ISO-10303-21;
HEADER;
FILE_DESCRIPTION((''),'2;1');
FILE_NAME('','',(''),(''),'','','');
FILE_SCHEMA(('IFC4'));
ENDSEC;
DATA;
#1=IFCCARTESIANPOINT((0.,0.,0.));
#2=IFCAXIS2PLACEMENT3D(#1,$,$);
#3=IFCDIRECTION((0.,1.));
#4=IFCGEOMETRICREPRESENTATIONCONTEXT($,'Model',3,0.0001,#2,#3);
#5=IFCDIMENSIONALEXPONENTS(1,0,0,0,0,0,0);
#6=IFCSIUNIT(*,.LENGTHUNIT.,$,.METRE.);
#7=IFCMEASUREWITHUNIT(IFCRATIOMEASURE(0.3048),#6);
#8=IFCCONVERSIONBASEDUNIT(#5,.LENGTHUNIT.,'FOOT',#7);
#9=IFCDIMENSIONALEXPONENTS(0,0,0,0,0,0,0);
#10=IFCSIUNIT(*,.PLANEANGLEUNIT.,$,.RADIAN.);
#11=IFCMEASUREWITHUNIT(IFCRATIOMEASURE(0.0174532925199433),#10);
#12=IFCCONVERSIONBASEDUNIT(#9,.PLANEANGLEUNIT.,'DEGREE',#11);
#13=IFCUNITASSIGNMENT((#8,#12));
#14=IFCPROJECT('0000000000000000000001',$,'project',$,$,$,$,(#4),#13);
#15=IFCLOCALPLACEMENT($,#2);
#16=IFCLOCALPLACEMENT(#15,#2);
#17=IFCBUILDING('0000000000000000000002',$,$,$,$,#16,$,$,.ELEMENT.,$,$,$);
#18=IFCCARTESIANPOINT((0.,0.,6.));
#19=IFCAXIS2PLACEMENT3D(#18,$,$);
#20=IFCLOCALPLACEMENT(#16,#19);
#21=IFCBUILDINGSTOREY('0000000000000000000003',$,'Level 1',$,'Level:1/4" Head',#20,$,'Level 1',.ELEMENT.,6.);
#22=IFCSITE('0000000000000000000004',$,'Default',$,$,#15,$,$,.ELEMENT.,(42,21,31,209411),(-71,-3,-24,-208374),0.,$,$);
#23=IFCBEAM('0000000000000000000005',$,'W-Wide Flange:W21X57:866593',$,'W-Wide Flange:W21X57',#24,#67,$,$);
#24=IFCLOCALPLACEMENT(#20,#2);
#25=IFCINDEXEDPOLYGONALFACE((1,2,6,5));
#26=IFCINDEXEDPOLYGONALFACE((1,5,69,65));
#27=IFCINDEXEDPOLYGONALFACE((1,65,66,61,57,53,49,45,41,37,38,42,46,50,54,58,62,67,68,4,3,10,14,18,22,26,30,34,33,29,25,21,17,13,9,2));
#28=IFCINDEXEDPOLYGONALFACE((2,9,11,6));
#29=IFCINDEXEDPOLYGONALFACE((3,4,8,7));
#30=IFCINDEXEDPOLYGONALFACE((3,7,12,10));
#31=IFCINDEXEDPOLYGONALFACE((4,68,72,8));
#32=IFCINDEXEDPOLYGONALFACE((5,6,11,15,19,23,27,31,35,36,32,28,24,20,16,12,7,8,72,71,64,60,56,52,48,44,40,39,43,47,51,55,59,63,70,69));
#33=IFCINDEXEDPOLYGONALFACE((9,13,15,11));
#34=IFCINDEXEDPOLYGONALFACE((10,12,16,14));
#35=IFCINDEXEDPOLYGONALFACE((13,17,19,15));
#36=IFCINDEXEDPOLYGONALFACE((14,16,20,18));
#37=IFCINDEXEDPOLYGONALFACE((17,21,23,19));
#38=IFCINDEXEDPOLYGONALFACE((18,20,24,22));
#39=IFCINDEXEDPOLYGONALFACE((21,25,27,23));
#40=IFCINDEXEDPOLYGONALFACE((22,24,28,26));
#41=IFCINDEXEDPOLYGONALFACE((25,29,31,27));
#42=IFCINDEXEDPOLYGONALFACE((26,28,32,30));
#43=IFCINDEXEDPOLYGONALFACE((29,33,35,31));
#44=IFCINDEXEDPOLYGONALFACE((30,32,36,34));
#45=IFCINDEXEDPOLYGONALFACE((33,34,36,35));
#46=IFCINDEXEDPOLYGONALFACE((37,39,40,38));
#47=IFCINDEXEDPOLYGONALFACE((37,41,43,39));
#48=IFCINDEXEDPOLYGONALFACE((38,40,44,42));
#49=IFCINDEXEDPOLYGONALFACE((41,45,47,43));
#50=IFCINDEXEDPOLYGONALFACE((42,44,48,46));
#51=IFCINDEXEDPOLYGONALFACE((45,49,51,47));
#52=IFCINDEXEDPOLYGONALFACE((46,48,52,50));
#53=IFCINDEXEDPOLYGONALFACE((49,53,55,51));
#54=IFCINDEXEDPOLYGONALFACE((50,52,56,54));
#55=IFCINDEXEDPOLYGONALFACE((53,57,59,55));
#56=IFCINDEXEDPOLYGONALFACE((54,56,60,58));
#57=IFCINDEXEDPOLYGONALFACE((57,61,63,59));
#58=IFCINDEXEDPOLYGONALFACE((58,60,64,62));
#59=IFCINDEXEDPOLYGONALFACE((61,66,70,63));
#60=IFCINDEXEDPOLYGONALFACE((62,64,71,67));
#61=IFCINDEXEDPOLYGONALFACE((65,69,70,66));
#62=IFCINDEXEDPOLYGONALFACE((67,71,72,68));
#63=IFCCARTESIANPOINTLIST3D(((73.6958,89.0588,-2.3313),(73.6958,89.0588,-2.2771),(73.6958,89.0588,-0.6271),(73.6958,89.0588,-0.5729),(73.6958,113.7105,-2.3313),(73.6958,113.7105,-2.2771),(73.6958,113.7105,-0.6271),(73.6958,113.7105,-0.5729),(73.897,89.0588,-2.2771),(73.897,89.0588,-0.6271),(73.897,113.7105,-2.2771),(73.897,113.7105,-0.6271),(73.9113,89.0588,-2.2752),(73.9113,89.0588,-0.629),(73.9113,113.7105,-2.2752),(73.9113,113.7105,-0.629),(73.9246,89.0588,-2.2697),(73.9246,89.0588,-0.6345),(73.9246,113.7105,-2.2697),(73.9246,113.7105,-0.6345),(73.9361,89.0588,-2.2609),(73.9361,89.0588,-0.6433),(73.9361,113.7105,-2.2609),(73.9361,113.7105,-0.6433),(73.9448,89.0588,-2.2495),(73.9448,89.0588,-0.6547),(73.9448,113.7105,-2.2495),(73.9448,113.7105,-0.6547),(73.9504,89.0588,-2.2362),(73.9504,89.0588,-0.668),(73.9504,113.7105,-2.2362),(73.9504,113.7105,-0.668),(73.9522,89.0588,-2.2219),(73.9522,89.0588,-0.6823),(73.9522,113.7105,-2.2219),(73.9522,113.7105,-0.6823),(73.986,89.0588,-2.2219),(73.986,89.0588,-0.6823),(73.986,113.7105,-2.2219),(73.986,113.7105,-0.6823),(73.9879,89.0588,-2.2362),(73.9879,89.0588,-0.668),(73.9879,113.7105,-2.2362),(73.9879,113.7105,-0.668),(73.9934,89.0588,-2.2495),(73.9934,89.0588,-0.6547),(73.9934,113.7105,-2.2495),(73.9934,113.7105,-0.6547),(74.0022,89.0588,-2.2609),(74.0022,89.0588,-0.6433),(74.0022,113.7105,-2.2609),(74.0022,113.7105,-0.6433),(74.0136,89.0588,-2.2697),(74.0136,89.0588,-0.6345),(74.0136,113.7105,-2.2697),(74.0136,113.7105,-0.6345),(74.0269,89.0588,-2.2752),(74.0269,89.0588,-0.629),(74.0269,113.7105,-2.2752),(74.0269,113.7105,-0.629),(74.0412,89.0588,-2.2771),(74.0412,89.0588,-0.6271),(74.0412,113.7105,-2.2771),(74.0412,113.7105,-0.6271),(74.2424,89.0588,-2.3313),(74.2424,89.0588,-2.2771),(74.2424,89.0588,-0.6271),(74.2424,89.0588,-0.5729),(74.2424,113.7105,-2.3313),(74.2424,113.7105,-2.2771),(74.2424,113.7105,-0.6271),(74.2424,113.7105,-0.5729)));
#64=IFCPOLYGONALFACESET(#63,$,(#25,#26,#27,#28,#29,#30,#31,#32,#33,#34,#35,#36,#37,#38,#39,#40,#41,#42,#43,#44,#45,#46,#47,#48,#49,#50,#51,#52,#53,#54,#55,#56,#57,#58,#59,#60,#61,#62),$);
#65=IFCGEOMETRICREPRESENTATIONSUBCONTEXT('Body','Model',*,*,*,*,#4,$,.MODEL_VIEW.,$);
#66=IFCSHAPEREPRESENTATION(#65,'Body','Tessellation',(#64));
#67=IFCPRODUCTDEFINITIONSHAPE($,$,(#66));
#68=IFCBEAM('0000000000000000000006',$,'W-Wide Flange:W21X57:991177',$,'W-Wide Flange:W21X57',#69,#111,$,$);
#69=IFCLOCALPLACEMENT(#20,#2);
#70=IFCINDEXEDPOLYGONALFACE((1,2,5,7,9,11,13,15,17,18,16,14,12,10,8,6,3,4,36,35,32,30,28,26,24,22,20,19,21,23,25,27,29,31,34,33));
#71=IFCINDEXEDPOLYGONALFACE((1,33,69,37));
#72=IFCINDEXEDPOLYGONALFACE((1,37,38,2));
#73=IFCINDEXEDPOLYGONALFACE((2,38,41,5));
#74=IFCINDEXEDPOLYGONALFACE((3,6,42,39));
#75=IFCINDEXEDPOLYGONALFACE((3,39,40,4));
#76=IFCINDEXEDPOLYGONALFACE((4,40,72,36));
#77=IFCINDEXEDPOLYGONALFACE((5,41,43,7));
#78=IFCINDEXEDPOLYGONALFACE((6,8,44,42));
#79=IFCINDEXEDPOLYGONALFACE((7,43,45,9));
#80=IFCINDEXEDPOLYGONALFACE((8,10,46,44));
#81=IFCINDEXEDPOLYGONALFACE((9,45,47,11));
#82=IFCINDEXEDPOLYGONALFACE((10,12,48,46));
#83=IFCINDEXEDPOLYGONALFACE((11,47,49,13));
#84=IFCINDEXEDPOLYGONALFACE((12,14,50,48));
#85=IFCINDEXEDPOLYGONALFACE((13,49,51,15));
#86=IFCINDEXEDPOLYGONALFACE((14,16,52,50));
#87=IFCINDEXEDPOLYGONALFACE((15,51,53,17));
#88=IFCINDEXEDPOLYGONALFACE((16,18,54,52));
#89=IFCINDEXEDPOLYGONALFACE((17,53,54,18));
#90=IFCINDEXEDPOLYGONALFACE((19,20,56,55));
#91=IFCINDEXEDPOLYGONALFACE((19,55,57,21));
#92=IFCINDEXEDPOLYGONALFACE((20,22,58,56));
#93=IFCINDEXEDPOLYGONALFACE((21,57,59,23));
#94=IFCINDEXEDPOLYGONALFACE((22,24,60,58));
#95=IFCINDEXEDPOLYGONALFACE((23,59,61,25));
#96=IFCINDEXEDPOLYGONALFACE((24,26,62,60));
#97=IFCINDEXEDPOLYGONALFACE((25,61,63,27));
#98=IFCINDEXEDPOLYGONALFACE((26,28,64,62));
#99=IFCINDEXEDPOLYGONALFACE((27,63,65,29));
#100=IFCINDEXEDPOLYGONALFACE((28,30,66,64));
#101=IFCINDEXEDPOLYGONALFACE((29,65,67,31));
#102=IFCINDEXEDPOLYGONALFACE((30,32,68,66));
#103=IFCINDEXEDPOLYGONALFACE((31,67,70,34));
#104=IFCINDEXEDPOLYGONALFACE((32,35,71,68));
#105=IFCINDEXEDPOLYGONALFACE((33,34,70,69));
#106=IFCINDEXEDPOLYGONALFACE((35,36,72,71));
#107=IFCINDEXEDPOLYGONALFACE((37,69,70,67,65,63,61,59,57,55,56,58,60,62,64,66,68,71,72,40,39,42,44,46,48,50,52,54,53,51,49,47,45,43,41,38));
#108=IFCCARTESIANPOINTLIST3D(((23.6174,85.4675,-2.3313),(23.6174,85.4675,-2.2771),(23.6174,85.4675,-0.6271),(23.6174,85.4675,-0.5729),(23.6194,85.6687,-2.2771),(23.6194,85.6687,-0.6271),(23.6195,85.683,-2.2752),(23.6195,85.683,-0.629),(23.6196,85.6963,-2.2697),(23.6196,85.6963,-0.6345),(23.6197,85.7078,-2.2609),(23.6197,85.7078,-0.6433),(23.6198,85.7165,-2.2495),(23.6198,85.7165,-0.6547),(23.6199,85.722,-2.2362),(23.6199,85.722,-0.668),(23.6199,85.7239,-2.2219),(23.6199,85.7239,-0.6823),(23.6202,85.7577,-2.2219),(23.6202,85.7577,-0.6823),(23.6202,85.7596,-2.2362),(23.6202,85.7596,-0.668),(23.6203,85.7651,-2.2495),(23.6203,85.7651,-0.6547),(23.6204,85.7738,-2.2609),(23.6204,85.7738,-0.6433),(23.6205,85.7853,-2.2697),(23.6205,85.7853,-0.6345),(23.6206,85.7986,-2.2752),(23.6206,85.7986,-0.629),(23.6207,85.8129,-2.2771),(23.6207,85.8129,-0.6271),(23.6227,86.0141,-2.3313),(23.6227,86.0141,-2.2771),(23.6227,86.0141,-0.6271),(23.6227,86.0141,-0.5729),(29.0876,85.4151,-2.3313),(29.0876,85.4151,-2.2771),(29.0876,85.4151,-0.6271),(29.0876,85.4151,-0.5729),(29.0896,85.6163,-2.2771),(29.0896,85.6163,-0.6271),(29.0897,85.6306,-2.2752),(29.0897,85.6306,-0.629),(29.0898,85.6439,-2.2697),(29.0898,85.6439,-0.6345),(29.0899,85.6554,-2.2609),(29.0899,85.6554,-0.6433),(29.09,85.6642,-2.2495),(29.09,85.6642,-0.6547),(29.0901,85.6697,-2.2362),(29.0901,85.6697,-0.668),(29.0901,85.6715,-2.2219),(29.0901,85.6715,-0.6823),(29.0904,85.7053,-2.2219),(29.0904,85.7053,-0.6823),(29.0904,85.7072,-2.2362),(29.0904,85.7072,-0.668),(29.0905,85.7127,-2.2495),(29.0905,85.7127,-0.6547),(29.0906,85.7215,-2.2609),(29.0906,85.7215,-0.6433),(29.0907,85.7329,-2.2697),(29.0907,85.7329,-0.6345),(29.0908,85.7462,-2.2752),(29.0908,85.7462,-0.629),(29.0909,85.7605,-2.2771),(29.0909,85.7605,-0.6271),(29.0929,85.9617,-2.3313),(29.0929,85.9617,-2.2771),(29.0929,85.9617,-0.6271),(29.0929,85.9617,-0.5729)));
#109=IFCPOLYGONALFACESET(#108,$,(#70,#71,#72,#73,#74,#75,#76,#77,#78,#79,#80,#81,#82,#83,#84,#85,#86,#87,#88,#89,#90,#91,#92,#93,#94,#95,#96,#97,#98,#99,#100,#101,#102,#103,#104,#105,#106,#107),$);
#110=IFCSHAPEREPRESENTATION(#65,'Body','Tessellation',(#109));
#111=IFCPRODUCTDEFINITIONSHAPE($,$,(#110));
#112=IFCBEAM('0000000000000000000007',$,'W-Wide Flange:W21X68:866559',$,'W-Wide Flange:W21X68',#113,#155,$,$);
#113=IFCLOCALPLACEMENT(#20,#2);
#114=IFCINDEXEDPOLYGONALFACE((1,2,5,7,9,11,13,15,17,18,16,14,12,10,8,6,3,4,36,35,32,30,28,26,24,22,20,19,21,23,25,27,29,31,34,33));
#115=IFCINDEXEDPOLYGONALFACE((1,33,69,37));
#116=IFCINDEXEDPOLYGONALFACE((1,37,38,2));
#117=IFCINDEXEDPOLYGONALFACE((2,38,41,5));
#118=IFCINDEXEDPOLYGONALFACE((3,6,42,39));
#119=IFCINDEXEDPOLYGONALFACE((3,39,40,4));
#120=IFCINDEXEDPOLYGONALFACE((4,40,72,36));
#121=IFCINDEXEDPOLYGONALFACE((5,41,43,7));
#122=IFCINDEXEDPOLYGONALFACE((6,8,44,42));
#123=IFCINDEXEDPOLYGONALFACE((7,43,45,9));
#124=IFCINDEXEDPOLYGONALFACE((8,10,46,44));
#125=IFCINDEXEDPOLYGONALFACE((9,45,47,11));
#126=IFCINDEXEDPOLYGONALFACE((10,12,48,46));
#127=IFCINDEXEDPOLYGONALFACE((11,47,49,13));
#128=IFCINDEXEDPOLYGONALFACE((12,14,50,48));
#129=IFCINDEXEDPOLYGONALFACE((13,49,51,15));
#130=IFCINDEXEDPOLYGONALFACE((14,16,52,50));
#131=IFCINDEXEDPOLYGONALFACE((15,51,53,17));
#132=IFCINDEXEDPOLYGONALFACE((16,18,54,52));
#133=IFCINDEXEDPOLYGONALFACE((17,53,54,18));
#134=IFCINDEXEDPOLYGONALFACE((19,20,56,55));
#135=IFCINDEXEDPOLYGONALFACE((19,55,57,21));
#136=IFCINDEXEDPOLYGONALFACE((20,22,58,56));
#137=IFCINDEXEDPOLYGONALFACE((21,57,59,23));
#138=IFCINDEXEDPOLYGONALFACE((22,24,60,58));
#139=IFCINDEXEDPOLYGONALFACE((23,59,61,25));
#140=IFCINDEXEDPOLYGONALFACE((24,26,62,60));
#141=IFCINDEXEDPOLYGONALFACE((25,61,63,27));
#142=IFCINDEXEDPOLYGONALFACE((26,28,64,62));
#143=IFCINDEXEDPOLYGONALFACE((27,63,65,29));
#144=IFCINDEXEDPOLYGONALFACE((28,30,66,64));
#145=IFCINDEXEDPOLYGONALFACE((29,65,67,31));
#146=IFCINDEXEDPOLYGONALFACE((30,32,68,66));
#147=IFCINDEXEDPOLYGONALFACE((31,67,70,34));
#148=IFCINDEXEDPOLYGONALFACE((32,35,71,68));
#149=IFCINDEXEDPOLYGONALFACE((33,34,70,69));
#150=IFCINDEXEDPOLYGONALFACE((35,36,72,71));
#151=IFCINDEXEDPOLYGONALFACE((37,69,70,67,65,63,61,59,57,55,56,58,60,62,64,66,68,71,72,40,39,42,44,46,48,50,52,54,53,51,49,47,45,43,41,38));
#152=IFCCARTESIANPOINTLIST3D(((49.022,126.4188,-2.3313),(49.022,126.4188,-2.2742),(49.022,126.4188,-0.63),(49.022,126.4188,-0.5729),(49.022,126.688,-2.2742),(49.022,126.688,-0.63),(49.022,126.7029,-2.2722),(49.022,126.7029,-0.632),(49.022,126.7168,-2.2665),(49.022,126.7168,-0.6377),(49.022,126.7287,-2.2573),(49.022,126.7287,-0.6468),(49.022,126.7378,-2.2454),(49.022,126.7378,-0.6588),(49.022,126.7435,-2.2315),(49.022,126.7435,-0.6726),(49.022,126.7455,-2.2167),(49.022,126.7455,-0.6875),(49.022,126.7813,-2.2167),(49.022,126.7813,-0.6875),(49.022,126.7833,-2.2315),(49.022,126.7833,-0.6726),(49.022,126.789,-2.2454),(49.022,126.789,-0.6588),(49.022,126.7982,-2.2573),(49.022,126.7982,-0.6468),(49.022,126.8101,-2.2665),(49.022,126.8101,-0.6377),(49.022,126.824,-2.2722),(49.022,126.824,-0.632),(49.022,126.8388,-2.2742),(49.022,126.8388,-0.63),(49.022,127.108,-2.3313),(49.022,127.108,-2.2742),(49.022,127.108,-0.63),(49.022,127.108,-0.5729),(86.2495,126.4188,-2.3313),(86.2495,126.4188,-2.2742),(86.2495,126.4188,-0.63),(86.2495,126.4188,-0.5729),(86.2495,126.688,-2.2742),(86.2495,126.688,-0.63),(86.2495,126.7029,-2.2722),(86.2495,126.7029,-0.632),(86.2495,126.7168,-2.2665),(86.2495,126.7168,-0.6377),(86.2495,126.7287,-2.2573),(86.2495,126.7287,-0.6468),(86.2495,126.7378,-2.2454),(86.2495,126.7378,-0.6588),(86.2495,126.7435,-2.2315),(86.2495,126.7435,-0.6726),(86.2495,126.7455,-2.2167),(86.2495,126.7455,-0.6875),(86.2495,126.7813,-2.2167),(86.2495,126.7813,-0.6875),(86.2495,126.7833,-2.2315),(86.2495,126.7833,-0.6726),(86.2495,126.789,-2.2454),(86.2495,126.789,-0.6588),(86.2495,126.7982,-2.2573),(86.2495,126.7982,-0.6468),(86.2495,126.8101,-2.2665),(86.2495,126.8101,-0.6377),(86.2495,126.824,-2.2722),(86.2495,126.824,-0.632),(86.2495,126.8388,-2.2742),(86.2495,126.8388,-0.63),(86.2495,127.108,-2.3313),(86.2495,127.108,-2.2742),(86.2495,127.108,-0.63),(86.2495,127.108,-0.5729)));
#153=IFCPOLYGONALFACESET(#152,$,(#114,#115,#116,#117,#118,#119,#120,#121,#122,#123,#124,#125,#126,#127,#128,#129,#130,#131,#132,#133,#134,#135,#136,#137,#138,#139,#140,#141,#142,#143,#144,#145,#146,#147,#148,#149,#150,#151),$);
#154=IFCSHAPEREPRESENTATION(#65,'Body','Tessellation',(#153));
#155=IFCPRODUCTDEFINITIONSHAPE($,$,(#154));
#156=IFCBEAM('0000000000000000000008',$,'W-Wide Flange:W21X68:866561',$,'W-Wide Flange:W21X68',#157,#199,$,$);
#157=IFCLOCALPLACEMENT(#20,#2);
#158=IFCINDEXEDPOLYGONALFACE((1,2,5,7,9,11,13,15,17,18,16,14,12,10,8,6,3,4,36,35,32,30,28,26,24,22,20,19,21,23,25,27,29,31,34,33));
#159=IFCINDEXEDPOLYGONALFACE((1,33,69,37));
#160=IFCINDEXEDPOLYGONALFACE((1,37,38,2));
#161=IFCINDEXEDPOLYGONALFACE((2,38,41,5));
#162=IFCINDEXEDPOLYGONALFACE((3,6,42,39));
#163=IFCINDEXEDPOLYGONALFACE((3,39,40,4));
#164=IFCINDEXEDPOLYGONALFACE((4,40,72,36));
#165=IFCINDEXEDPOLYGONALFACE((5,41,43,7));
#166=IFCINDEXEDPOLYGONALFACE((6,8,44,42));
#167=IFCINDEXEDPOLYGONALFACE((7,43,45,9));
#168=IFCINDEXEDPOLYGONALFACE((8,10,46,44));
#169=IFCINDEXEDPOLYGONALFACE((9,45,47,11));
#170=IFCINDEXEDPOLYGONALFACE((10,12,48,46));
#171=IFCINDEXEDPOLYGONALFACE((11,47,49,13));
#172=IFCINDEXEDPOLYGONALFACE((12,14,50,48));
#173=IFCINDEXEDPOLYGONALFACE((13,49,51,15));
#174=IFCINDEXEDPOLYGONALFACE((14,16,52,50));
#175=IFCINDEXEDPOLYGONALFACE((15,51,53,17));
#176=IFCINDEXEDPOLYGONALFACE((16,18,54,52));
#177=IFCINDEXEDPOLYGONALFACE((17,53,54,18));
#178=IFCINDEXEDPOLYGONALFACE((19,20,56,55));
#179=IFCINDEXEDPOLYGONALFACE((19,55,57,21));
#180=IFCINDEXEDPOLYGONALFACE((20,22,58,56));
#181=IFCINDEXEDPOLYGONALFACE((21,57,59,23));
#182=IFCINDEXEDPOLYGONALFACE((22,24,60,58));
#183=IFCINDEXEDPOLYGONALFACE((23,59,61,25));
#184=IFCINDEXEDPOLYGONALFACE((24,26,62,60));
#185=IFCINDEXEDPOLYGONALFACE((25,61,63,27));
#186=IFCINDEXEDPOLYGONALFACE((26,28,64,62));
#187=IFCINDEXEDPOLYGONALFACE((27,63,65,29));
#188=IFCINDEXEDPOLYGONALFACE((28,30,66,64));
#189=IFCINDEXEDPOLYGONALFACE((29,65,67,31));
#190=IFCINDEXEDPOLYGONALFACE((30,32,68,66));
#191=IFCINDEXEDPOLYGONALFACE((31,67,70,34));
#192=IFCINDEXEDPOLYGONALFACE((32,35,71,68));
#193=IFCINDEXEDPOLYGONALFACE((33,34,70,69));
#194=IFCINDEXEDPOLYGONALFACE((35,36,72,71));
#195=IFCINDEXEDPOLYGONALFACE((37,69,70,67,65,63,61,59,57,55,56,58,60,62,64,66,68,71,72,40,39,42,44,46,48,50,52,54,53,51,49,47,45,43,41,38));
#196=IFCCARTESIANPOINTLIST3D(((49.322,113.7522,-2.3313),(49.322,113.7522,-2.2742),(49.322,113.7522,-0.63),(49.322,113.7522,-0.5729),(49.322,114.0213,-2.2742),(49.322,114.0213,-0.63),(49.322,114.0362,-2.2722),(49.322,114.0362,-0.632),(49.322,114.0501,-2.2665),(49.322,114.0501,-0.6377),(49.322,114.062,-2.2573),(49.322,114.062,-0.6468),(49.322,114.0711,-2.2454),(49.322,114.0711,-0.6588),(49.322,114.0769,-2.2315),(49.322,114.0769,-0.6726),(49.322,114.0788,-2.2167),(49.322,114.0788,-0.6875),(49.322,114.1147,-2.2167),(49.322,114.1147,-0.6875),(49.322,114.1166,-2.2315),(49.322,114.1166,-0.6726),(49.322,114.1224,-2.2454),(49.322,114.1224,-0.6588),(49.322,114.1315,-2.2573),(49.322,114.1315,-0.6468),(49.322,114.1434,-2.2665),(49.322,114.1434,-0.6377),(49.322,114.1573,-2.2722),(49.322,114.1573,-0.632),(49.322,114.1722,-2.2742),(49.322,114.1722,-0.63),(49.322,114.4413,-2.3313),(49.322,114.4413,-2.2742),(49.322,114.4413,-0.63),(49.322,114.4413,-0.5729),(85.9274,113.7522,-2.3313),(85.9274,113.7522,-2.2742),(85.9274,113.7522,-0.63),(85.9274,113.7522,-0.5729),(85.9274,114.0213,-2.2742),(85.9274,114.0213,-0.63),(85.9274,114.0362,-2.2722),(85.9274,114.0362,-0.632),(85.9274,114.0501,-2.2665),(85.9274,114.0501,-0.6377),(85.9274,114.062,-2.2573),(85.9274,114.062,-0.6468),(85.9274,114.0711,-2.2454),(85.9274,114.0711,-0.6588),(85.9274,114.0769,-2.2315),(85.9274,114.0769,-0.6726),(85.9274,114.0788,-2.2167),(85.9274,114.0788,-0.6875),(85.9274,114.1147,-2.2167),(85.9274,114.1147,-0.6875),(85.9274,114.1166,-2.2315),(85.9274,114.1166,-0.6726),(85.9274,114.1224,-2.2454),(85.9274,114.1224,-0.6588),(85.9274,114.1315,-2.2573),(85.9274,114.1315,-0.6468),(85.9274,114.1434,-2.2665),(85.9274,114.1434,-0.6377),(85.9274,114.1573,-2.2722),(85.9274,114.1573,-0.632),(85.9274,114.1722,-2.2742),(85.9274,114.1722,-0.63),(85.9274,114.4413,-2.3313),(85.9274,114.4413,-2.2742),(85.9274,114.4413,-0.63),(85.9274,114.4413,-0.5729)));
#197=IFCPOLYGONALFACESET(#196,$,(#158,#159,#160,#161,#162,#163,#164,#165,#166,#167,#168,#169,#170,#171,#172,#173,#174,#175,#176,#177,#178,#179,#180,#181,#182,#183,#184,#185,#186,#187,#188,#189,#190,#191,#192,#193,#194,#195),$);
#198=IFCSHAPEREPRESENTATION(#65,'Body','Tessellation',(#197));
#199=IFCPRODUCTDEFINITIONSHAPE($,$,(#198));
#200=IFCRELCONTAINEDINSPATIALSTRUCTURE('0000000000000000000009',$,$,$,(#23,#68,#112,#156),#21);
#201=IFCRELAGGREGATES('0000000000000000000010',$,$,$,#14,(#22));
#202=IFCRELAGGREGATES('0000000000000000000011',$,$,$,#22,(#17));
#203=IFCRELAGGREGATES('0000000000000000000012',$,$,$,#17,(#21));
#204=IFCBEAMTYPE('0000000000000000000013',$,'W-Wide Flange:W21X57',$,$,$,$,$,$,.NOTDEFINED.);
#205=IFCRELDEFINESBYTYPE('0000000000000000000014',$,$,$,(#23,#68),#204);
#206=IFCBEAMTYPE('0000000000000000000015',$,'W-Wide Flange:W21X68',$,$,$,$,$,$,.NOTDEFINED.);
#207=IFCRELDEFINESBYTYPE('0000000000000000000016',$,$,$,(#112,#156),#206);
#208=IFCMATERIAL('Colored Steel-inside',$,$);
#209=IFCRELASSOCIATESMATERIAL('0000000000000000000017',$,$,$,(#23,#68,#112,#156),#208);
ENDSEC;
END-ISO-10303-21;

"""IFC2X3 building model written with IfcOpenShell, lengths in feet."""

from ifc_helpers import new_model, entity, si_unit, converted_unit, direction, frame, frame_2d, origin, place, context, subcontext, project, spatial, i_section, extrude, material, type_object, element, save


model = new_model("IFC2X3")

# Units and contexts
model_context = context("Model", 3, precision=0.0001, world=origin(), true_north=direction((0.0, 1.0)))
body_context = subcontext(model_context, "Body", "Model", "MODEL_VIEW")
ifc_project = project(units=[converted_unit("LENGTHUNIT", "FOOT", entity("IfcRatioMeasure", 0.3048), si_unit("LENGTHUNIT", "METRE"), dimensions=[1, 0, 0, 0, 0, 0, 0]), converted_unit("PLANEANGLEUNIT", "DEGREE", entity("IfcRatioMeasure", 0.0174532925199433), si_unit("PLANEANGLEUNIT", "RADIAN"), dimensions=[0, 0, 0, 0, 0, 0, 0])], contexts=[model_context])

# Site, building, storey
site_placement = place(None, origin())
site = spatial("IfcSite", under=ifc_project, at=site_placement, Name="Default", CompositionType="ELEMENT", RefLatitude=(42, 21, 31, 209411), RefLongitude=(-71, -3, -24, -208374), RefElevation=0.0)
building_placement = place(site_placement, origin())
building = spatial("IfcBuilding", under=site, at=building_placement, CompositionType="ELEMENT")
storey_placement = place(building_placement, frame((0.0, 0.0, 6.0)))
storey = spatial("IfcBuildingStorey", under=building, at=storey_placement, Name="Level 1", ObjectType="Level:1/4\" Head", LongName="Level 1", CompositionType="ELEMENT", Elevation=6.0)

# Shared definitions
ifc_material_1 = material(Name="Colored Steel-inside")

# Beams
beam_type_1 = type_object("IfcBeamType", Name="W-Wide Flange:W21X57", PredefinedType="NOTDEFINED")
beam_1_placement = place(storey_placement, frame((73.9691, 114.0968, 0.0), z_axis=(0.0, 0.0, 1.0), x_axis=(0.0, -1.0, 0.0)))
element("IfcBeam", 1, at=beam_1_placement, inside=storey, type_object=beam_type_1, material=ifc_material_1, Name="W-Wide Flange:W21X57:866593", ObjectType="W-Wide Flange:W21X57", context=body_context, shape_type="SweptSolid", body=[
    extrude(i_section(OverallWidth=0.5467, OverallDepth=1.7583, WebThickness=0.0337, FlangeThickness=0.0542, FilletRadius=0.0552, at=frame_2d((0.0, 0.0), x_axis=(0.0, 1.0))), frame((0.3863, 0.0, -1.4521), z_axis=(1.0, 0.0, 0.0), x_axis=(0.0, 0.0, -1.0)), (0.0, 0.0, 1.0), 24.6517),
])
beam_2_placement = place(storey_placement, frame((29.6345, 85.6832, 0.0), z_axis=(0.0, 0.0, 1.0), x_axis=(-0.999954, 0.009574, 0.0)))
element("IfcBeam", 2, at=beam_2_placement, inside=storey, type_object=beam_type_1, material=ifc_material_1, Name="W-Wide Flange:W21X57:991177", ObjectType="W-Wide Flange:W21X57", context=body_context, shape_type="SweptSolid", body=[
    extrude(i_section(OverallWidth=0.5467, OverallDepth=1.7583, WebThickness=0.0337, FlangeThickness=0.0542, FilletRadius=0.0552, at=frame_2d((0.0, 0.0), x_axis=(0.0, 1.0))), frame((0.5443, 0.0, -1.4521), z_axis=(1.0, 0.0, 0.0), x_axis=(0.0, 0.0, -1.0)), (0.0, 0.0, 1.0), 5.4704),
])
beam_type_2 = type_object("IfcBeamType", Name="W-Wide Flange:W21X68", PredefinedType="NOTDEFINED")
beam_3_placement = place(storey_placement, frame((48.6358, 126.7634, 0.0)))
element("IfcBeam", 3, at=beam_3_placement, inside=storey, type_object=beam_type_2, material=ifc_material_1, Name="W-Wide Flange:W21X68:866559", ObjectType="W-Wide Flange:W21X68", context=body_context, shape_type="SweptSolid", body=[
    extrude(i_section(OverallWidth=0.6892, OverallDepth=1.7583, WebThickness=0.0358, FlangeThickness=0.0571, FilletRadius=0.0575, at=frame_2d((0.0, 0.0), x_axis=(0.0, 1.0))), frame((0.3863, 0.0, -1.4521), z_axis=(1.0, 0.0, 0.0), x_axis=(0.0, 0.0, -1.0)), (0.0, 0.0, 1.0), 37.2275),
])
beam_4_placement = place(storey_placement, frame((49.6554, 114.0968, 0.0)))
element("IfcBeam", 4, at=beam_4_placement, inside=storey, type_object=beam_type_2, material=ifc_material_1, Name="W-Wide Flange:W21X68:866561", ObjectType="W-Wide Flange:W21X68", context=body_context, shape_type="SweptSolid", body=[
    extrude(i_section(OverallWidth=0.6892, OverallDepth=1.7583, WebThickness=0.0358, FlangeThickness=0.0571, FilletRadius=0.0575, at=frame_2d((0.0, 0.0), x_axis=(0.0, 1.0))), frame((-0.3333, 0.0, -1.4521), z_axis=(1.0, 0.0, 0.0), x_axis=(0.0, 0.0, -1.0)), (0.0, 0.0, 1.0), 36.6054),
])

save(model, "model.ifc")
